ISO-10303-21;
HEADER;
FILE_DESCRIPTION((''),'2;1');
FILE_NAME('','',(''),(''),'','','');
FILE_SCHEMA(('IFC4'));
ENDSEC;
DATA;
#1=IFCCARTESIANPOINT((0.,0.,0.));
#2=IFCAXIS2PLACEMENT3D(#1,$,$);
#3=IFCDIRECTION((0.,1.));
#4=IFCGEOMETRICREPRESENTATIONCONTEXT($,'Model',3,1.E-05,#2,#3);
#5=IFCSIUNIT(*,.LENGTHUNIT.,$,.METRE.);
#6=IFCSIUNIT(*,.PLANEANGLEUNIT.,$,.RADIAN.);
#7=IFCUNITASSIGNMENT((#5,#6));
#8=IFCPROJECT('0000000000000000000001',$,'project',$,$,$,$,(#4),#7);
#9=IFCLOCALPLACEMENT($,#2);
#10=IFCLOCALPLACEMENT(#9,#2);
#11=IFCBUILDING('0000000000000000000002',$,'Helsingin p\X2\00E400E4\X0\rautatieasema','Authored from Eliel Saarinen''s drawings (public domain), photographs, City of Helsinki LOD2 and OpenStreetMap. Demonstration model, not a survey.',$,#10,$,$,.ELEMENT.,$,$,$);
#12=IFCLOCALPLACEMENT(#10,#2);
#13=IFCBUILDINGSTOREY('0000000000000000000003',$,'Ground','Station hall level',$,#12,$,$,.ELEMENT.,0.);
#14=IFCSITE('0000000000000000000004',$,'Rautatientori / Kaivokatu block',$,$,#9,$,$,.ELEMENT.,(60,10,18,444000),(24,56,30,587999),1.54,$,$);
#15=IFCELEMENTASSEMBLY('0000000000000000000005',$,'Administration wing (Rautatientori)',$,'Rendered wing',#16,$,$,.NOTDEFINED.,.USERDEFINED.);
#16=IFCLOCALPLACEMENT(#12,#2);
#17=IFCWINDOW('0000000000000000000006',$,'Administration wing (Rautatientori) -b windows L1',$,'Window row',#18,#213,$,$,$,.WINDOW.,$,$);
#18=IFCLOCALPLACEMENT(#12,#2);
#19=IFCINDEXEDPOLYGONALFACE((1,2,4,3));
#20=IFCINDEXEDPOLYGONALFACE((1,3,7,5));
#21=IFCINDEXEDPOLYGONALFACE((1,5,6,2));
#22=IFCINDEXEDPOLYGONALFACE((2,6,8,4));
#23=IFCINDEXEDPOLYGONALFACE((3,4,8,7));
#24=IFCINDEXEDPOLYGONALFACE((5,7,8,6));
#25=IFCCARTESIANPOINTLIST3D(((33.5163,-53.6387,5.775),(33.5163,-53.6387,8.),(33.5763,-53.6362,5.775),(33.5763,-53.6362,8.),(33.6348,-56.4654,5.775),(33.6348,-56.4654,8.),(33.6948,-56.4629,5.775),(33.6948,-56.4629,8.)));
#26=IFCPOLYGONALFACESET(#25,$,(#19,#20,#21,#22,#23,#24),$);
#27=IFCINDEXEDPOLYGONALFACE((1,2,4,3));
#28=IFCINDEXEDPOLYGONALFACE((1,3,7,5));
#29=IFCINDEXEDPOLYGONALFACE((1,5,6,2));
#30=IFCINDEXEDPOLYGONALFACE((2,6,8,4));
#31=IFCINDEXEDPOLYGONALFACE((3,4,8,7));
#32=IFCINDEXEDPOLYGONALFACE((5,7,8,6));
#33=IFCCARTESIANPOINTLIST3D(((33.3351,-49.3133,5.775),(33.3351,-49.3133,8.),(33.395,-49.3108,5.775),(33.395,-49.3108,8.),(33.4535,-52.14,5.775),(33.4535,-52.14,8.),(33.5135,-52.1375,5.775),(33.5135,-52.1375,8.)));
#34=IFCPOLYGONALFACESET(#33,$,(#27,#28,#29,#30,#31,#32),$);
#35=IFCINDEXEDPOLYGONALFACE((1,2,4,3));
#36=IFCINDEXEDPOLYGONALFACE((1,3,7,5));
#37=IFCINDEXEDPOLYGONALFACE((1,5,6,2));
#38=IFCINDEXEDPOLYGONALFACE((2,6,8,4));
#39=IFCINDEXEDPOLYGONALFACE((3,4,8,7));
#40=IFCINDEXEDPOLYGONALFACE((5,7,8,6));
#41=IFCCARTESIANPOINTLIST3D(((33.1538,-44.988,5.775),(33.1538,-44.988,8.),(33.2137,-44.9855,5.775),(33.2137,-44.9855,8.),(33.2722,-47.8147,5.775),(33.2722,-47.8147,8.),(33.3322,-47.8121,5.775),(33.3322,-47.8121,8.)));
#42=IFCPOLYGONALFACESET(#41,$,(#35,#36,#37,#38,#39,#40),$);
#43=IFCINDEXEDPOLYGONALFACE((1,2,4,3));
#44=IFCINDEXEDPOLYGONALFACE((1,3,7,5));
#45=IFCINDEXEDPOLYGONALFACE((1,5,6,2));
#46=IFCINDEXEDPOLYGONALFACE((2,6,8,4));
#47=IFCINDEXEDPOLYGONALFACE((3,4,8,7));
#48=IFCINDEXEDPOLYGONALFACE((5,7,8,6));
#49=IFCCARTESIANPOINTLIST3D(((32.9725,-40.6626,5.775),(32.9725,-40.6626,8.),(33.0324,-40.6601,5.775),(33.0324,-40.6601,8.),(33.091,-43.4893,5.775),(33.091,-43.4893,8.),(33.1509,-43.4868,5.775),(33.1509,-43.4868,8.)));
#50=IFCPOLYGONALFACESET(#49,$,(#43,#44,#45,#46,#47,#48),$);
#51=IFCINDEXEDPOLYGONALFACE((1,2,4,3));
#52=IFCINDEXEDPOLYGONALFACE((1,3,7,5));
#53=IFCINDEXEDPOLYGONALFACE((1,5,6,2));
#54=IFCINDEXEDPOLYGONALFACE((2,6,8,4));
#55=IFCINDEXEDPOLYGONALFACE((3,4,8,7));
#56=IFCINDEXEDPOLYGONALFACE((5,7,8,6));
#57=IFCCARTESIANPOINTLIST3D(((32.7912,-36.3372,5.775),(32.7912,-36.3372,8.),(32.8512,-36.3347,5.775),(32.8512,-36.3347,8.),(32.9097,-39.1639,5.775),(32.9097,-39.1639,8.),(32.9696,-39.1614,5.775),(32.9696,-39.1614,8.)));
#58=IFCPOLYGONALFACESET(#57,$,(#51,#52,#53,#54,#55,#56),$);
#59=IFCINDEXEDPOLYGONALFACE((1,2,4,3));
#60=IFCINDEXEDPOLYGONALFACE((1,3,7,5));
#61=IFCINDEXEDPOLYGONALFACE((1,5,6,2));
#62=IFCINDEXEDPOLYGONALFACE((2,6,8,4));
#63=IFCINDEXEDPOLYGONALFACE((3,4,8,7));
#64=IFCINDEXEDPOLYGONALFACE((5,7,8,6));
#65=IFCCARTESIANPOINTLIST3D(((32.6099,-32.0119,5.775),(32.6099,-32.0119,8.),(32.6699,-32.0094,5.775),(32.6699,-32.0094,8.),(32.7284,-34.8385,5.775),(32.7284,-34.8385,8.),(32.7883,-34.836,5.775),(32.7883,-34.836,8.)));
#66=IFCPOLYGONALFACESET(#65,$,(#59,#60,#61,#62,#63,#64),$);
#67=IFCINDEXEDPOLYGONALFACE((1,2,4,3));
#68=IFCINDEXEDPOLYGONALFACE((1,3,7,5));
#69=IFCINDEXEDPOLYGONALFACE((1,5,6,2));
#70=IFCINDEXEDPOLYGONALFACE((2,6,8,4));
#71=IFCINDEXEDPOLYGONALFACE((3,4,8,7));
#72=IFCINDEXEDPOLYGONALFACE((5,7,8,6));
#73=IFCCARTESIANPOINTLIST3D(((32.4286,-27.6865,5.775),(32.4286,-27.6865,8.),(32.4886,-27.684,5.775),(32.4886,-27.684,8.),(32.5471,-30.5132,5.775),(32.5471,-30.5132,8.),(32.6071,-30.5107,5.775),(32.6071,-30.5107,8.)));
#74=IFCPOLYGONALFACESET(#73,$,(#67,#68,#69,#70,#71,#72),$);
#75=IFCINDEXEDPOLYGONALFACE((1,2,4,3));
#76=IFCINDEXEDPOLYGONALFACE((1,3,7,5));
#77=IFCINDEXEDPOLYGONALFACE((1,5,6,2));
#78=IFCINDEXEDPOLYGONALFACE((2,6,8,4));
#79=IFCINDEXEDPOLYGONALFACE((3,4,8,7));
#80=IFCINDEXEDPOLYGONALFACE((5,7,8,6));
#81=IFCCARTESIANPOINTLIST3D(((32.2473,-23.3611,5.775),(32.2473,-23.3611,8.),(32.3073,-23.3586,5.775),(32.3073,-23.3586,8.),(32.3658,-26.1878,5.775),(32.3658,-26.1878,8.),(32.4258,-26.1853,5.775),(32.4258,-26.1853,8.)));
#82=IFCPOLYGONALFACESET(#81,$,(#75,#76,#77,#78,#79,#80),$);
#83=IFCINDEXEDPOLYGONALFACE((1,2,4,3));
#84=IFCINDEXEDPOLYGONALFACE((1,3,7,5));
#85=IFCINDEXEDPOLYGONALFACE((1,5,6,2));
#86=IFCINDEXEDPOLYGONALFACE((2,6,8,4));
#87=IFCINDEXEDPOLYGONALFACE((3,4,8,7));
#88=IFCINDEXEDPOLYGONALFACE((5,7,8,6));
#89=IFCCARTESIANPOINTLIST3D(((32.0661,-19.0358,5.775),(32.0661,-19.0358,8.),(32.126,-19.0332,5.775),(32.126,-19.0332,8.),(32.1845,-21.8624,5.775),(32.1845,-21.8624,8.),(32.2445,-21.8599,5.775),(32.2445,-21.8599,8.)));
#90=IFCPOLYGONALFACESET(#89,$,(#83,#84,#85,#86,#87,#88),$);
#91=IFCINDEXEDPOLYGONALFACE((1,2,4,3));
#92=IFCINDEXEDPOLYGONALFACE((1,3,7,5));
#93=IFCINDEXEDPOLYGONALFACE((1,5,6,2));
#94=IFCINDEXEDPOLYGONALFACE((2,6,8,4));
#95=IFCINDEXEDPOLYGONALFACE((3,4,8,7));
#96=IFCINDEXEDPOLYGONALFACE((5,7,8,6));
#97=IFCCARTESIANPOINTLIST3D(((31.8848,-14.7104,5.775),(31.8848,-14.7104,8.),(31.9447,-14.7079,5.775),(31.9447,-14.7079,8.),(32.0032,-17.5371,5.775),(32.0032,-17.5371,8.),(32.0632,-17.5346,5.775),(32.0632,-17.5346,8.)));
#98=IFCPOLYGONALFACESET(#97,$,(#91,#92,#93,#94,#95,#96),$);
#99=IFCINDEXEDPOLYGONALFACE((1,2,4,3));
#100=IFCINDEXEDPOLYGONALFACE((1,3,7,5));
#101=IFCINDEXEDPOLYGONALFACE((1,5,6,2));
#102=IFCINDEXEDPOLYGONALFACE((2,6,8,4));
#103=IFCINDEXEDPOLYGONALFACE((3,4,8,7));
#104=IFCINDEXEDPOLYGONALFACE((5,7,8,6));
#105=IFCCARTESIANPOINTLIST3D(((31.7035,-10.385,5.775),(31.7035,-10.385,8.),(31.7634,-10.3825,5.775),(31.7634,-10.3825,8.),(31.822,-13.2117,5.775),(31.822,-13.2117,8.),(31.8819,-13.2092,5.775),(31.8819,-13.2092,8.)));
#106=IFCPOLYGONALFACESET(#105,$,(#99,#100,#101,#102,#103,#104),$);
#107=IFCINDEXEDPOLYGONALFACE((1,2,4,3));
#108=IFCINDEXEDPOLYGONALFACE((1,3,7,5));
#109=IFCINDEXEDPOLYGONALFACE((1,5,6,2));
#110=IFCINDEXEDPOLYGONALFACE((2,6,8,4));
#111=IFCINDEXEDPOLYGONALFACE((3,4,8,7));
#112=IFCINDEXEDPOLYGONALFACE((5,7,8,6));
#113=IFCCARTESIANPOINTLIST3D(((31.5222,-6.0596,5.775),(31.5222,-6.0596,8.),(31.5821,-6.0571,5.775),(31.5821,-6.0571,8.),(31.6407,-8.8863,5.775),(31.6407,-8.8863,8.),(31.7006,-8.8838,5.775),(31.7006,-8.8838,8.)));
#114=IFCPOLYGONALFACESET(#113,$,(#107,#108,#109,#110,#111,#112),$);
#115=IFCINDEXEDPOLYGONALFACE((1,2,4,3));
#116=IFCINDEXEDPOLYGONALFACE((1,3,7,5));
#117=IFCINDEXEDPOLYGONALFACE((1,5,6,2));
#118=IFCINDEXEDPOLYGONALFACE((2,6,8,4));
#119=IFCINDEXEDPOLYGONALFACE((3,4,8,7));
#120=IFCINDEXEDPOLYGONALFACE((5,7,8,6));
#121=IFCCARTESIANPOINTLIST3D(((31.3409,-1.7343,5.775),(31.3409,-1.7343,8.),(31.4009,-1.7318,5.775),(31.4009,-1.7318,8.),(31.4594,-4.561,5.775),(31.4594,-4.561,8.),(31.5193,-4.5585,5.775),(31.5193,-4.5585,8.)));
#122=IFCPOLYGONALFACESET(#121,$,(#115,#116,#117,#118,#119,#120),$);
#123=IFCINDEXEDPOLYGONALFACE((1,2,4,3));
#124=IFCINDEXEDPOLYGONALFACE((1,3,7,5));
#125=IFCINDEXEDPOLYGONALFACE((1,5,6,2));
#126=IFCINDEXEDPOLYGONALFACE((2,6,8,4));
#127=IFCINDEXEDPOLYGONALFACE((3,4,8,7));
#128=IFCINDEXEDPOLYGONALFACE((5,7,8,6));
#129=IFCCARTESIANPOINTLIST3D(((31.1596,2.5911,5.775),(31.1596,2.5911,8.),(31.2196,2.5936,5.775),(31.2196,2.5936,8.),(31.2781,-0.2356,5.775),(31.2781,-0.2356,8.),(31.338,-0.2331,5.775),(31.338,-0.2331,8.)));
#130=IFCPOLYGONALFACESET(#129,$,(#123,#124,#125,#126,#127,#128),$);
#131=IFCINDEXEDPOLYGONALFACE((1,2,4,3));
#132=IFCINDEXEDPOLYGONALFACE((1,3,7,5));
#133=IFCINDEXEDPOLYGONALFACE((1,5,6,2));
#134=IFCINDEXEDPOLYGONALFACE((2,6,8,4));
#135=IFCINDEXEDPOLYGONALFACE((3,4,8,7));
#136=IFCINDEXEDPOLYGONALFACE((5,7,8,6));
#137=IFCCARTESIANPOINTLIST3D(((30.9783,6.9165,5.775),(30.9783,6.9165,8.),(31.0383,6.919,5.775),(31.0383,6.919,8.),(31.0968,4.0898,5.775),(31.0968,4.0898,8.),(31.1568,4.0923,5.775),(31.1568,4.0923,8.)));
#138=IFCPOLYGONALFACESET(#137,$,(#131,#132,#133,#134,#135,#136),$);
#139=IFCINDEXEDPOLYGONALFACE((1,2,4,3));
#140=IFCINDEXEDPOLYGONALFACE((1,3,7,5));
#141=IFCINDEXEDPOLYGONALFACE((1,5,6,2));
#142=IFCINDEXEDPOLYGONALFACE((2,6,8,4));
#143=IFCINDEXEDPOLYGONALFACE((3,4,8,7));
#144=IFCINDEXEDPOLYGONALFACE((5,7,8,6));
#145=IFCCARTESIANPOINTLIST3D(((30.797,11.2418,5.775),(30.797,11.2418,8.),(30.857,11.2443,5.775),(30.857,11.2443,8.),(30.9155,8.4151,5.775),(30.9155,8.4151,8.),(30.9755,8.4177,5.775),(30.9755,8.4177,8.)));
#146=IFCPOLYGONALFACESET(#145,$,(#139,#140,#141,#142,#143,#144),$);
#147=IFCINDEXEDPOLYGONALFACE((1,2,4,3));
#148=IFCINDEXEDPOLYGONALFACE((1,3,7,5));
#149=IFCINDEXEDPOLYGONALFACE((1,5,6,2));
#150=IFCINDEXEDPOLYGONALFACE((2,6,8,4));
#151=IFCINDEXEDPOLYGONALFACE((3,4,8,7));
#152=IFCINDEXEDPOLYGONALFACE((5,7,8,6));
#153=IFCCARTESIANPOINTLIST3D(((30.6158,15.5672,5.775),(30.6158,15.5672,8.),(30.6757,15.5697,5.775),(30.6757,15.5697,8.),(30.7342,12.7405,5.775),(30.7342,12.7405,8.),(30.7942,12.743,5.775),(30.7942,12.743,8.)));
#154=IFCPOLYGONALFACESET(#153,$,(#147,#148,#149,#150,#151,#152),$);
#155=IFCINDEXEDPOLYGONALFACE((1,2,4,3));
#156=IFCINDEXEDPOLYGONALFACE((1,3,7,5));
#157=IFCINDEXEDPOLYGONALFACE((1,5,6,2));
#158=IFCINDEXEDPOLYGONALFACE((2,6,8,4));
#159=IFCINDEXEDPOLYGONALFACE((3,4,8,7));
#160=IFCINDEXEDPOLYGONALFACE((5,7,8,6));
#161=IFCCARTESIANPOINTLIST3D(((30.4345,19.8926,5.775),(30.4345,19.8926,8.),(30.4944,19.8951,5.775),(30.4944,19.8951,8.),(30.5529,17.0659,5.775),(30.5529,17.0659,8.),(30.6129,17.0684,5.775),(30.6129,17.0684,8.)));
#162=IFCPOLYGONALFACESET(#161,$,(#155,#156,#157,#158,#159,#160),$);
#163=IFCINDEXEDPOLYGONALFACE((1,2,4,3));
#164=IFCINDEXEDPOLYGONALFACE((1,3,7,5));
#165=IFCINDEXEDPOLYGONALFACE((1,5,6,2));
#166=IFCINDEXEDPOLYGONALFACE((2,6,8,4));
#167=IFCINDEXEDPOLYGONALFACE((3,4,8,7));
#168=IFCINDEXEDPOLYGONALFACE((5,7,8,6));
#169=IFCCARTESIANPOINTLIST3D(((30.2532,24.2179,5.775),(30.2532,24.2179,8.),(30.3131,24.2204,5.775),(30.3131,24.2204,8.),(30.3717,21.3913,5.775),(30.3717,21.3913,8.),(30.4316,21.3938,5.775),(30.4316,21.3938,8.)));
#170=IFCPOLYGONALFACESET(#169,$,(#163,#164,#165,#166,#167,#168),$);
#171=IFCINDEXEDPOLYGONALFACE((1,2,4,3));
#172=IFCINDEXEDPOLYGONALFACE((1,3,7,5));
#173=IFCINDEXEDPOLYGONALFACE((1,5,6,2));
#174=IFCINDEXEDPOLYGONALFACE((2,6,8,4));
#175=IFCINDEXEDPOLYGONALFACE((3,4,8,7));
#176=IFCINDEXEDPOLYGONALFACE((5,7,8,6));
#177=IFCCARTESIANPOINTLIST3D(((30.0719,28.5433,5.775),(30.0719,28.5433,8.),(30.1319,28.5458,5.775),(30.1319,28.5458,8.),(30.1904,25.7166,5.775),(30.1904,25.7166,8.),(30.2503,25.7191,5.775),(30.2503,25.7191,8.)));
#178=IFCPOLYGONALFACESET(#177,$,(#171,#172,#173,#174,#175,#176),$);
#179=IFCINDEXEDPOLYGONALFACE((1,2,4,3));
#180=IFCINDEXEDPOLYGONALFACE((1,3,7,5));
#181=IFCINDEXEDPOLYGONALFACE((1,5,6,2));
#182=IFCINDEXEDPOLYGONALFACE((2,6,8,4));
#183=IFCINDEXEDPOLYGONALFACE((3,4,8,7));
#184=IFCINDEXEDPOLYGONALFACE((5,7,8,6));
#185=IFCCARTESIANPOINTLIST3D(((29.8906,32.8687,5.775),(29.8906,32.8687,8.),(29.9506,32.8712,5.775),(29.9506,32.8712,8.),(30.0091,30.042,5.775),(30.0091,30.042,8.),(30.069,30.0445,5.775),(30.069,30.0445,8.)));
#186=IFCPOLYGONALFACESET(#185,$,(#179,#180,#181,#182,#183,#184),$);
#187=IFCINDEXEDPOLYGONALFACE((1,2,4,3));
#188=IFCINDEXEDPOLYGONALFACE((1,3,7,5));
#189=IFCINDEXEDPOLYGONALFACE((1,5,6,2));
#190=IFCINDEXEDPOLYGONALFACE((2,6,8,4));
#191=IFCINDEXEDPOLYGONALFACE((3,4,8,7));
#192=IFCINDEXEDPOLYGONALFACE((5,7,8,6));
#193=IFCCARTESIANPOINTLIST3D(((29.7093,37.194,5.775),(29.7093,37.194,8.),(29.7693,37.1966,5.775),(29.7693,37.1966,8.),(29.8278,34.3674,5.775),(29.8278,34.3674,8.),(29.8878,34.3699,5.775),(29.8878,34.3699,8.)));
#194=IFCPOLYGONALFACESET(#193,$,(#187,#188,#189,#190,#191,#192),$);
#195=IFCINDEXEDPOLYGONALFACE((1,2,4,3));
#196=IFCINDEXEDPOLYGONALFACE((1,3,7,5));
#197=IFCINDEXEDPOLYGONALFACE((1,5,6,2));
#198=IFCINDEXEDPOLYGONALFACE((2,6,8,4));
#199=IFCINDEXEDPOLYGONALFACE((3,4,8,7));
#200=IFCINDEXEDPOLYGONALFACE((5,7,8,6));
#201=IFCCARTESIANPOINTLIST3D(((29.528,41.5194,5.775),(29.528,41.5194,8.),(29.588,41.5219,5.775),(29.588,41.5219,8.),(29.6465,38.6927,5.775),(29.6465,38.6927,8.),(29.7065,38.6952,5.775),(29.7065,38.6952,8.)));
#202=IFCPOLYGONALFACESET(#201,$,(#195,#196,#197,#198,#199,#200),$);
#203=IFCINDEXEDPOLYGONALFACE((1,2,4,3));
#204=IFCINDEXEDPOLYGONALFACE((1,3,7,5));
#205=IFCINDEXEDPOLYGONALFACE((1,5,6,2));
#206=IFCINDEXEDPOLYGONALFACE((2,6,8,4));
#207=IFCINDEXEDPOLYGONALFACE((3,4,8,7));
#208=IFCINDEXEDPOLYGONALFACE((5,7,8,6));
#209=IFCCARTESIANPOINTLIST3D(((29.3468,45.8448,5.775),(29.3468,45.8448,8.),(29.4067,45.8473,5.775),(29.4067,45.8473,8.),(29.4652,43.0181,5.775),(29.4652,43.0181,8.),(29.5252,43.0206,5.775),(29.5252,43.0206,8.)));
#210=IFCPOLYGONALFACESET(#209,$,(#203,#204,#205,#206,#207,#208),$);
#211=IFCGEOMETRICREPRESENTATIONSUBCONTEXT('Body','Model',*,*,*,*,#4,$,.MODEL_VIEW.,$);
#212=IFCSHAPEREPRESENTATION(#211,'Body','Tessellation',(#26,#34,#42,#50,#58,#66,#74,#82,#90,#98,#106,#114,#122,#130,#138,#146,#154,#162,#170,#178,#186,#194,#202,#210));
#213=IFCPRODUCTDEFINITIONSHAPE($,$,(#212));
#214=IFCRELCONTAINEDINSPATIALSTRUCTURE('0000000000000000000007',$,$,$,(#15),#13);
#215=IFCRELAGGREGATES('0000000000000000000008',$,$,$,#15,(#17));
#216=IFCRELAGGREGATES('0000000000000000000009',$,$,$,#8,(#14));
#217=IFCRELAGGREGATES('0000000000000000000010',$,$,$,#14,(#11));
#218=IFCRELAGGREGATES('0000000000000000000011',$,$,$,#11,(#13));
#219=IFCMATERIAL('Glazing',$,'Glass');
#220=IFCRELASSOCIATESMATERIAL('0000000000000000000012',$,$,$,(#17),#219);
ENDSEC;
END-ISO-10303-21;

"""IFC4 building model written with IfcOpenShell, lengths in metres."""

from ifc_helpers import new_model, si_unit, direction, frame, frame_2d, origin, place, context, subcontext, project, spatial, rectangle, extrude, material, element, aggregate, save


model = new_model("IFC4")

# Units and contexts
model_context = context("Model", 3, precision=1e-05, world=origin(), true_north=direction((0.0, 1.0)))
body_context = subcontext(model_context, "Body", "Model", "MODEL_VIEW")
ifc_project = project(units=[si_unit("LENGTHUNIT", "METRE"), si_unit("PLANEANGLEUNIT", "RADIAN")], contexts=[model_context])

# Site, building, storey
site_placement = place(None, origin())
site = spatial("IfcSite", under=ifc_project, at=site_placement, Name="Rautatientori / Kaivokatu block", CompositionType="ELEMENT", RefLatitude=(60, 10, 18, 444000), RefLongitude=(24, 56, 30, 587999), RefElevation=1.54)
building_placement = place(site_placement, origin())
building = spatial("IfcBuilding", under=site, at=building_placement, Name="Helsingin päärautatieasema", Description="Authored from Eliel Saarinen's drawings (public domain), photographs, City of Helsinki LOD2 and OpenStreetMap. Demonstration model, not a survey.", CompositionType="ELEMENT")
storey_placement = place(building_placement, origin())
storey = spatial("IfcBuildingStorey", under=building, at=storey_placement, Name="Ground", Description="Station hall level", CompositionType="ELEMENT", Elevation=0.0)

# Element assembly, window
assembly_placement = place(building_placement, origin())
assembly = element("IfcElementAssembly", 1, at=assembly_placement, inside=storey, Name="Administration wing (Rautatientori)", ObjectType="Rendered wing", AssemblyPlace="NOTDEFINED", PredefinedType="USERDEFINED")
ifc_material_1 = material(Name="Glazing", Category="Glass")
window_1_placement = place(building_placement, origin())
window_1 = element("IfcWindow", 2, at=window_1_placement, material=ifc_material_1, Name="Administration wing (Rautatientori) -b windows L1", ObjectType="Window row", PredefinedType="WINDOW", context=body_context, shape_type="SweptSolid", body=[
    extrude(rectangle(XDim=2.8292, YDim=0.06, at=frame_2d((0.0, 0.0), x_axis=(-0.041876, 0.999123))), frame((33.6056, -55.0508, 5.775)), (0.0, 0.0, 1.0), 2.225),
    extrude(rectangle(XDim=2.8292, YDim=0.06, at=frame_2d((0.0, 0.0), x_axis=(-0.041876, 0.999123))), frame((33.4243, -50.7254, 5.775)), (0.0, 0.0, 1.0), 2.225),
    extrude(rectangle(XDim=2.8292, YDim=0.06, at=frame_2d((0.0, 0.0), x_axis=(-0.041876, 0.999123))), frame((33.243, -46.4001, 5.775)), (0.0, 0.0, 1.0), 2.225),
    extrude(rectangle(XDim=2.8292, YDim=0.06, at=frame_2d((0.0, 0.0), x_axis=(-0.041876, 0.999123))), frame((33.0617, -42.0747, 5.775)), (0.0, 0.0, 1.0), 2.225),
    extrude(rectangle(XDim=2.8292, YDim=0.06, at=frame_2d((0.0, 0.0), x_axis=(-0.041876, 0.999123))), frame((32.8804, -37.7493, 5.775)), (0.0, 0.0, 1.0), 2.225),
    extrude(rectangle(XDim=2.8292, YDim=0.06, at=frame_2d((0.0, 0.0), x_axis=(-0.041876, 0.999123))), frame((32.6991, -33.4239, 5.775)), (0.0, 0.0, 1.0), 2.225),
    extrude(rectangle(XDim=2.8292, YDim=0.06, at=frame_2d((0.0, 0.0), x_axis=(-0.041876, 0.999123))), frame((32.5178, -29.0986, 5.775)), (0.0, 0.0, 1.0), 2.225),
    extrude(rectangle(XDim=2.8292, YDim=0.06, at=frame_2d((0.0, 0.0), x_axis=(-0.041876, 0.999123))), frame((32.3366, -24.7732, 5.775)), (0.0, 0.0, 1.0), 2.225),
    extrude(rectangle(XDim=2.8292, YDim=0.06, at=frame_2d((0.0, 0.0), x_axis=(-0.041876, 0.999123))), frame((32.1553, -20.4478, 5.775)), (0.0, 0.0, 1.0), 2.225),
    extrude(rectangle(XDim=2.8292, YDim=0.06, at=frame_2d((0.0, 0.0), x_axis=(-0.041876, 0.999123))), frame((31.974, -16.1225, 5.775)), (0.0, 0.0, 1.0), 2.225),
    extrude(rectangle(XDim=2.8292, YDim=0.06, at=frame_2d((0.0, 0.0), x_axis=(-0.041876, 0.999123))), frame((31.7927, -11.7971, 5.775)), (0.0, 0.0, 1.0), 2.225),
    extrude(rectangle(XDim=2.8292, YDim=0.06, at=frame_2d((0.0, 0.0), x_axis=(-0.041876, 0.999123))), frame((31.6114, -7.4717, 5.775)), (0.0, 0.0, 1.0), 2.225),
    extrude(rectangle(XDim=2.8292, YDim=0.06, at=frame_2d((0.0, 0.0), x_axis=(-0.041876, 0.999123))), frame((31.4301, -3.1464, 5.775)), (0.0, 0.0, 1.0), 2.225),
    extrude(rectangle(XDim=2.8292, YDim=0.06, at=frame_2d((0.0, 0.0), x_axis=(-0.041876, 0.999123))), frame((31.2488, 1.179, 5.775)), (0.0, 0.0, 1.0), 2.225),
    extrude(rectangle(XDim=2.8292, YDim=0.06, at=frame_2d((0.0, 0.0), x_axis=(-0.041876, 0.999123))), frame((31.0675, 5.5044, 5.775)), (0.0, 0.0, 1.0), 2.225),
    extrude(rectangle(XDim=2.8292, YDim=0.06, at=frame_2d((0.0, 0.0), x_axis=(-0.041876, 0.999123))), frame((30.8863, 9.8297, 5.775)), (0.0, 0.0, 1.0), 2.225),
    extrude(rectangle(XDim=2.8292, YDim=0.06, at=frame_2d((0.0, 0.0), x_axis=(-0.041876, 0.999123))), frame((30.705, 14.1551, 5.775)), (0.0, 0.0, 1.0), 2.225),
    extrude(rectangle(XDim=2.8292, YDim=0.06, at=frame_2d((0.0, 0.0), x_axis=(-0.041876, 0.999123))), frame((30.5237, 18.4805, 5.775)), (0.0, 0.0, 1.0), 2.225),
    extrude(rectangle(XDim=2.8292, YDim=0.06, at=frame_2d((0.0, 0.0), x_axis=(-0.041876, 0.999123))), frame((30.3424, 22.8059, 5.775)), (0.0, 0.0, 1.0), 2.225),
    extrude(rectangle(XDim=2.8292, YDim=0.06, at=frame_2d((0.0, 0.0), x_axis=(-0.041876, 0.999123))), frame((30.1611, 27.1312, 5.775)), (0.0, 0.0, 1.0), 2.225),
    extrude(rectangle(XDim=2.8292, YDim=0.06, at=frame_2d((0.0, 0.0), x_axis=(-0.041876, 0.999123))), frame((29.9798, 31.4566, 5.775)), (0.0, 0.0, 1.0), 2.225),
    extrude(rectangle(XDim=2.8292, YDim=0.06, at=frame_2d((0.0, 0.0), x_axis=(-0.041876, 0.999123))), frame((29.7985, 35.782, 5.775)), (0.0, 0.0, 1.0), 2.225),
    extrude(rectangle(XDim=2.8292, YDim=0.06, at=frame_2d((0.0, 0.0), x_axis=(-0.041876, 0.999123))), frame((29.6173, 40.1073, 5.775)), (0.0, 0.0, 1.0), 2.225),
    extrude(rectangle(XDim=2.8292, YDim=0.06, at=frame_2d((0.0, 0.0), x_axis=(-0.041876, 0.999123))), frame((29.436, 44.4327, 5.775)), (0.0, 0.0, 1.0), 2.225),
])
aggregate(assembly, [window_1])

save(model, "model.ifc")
